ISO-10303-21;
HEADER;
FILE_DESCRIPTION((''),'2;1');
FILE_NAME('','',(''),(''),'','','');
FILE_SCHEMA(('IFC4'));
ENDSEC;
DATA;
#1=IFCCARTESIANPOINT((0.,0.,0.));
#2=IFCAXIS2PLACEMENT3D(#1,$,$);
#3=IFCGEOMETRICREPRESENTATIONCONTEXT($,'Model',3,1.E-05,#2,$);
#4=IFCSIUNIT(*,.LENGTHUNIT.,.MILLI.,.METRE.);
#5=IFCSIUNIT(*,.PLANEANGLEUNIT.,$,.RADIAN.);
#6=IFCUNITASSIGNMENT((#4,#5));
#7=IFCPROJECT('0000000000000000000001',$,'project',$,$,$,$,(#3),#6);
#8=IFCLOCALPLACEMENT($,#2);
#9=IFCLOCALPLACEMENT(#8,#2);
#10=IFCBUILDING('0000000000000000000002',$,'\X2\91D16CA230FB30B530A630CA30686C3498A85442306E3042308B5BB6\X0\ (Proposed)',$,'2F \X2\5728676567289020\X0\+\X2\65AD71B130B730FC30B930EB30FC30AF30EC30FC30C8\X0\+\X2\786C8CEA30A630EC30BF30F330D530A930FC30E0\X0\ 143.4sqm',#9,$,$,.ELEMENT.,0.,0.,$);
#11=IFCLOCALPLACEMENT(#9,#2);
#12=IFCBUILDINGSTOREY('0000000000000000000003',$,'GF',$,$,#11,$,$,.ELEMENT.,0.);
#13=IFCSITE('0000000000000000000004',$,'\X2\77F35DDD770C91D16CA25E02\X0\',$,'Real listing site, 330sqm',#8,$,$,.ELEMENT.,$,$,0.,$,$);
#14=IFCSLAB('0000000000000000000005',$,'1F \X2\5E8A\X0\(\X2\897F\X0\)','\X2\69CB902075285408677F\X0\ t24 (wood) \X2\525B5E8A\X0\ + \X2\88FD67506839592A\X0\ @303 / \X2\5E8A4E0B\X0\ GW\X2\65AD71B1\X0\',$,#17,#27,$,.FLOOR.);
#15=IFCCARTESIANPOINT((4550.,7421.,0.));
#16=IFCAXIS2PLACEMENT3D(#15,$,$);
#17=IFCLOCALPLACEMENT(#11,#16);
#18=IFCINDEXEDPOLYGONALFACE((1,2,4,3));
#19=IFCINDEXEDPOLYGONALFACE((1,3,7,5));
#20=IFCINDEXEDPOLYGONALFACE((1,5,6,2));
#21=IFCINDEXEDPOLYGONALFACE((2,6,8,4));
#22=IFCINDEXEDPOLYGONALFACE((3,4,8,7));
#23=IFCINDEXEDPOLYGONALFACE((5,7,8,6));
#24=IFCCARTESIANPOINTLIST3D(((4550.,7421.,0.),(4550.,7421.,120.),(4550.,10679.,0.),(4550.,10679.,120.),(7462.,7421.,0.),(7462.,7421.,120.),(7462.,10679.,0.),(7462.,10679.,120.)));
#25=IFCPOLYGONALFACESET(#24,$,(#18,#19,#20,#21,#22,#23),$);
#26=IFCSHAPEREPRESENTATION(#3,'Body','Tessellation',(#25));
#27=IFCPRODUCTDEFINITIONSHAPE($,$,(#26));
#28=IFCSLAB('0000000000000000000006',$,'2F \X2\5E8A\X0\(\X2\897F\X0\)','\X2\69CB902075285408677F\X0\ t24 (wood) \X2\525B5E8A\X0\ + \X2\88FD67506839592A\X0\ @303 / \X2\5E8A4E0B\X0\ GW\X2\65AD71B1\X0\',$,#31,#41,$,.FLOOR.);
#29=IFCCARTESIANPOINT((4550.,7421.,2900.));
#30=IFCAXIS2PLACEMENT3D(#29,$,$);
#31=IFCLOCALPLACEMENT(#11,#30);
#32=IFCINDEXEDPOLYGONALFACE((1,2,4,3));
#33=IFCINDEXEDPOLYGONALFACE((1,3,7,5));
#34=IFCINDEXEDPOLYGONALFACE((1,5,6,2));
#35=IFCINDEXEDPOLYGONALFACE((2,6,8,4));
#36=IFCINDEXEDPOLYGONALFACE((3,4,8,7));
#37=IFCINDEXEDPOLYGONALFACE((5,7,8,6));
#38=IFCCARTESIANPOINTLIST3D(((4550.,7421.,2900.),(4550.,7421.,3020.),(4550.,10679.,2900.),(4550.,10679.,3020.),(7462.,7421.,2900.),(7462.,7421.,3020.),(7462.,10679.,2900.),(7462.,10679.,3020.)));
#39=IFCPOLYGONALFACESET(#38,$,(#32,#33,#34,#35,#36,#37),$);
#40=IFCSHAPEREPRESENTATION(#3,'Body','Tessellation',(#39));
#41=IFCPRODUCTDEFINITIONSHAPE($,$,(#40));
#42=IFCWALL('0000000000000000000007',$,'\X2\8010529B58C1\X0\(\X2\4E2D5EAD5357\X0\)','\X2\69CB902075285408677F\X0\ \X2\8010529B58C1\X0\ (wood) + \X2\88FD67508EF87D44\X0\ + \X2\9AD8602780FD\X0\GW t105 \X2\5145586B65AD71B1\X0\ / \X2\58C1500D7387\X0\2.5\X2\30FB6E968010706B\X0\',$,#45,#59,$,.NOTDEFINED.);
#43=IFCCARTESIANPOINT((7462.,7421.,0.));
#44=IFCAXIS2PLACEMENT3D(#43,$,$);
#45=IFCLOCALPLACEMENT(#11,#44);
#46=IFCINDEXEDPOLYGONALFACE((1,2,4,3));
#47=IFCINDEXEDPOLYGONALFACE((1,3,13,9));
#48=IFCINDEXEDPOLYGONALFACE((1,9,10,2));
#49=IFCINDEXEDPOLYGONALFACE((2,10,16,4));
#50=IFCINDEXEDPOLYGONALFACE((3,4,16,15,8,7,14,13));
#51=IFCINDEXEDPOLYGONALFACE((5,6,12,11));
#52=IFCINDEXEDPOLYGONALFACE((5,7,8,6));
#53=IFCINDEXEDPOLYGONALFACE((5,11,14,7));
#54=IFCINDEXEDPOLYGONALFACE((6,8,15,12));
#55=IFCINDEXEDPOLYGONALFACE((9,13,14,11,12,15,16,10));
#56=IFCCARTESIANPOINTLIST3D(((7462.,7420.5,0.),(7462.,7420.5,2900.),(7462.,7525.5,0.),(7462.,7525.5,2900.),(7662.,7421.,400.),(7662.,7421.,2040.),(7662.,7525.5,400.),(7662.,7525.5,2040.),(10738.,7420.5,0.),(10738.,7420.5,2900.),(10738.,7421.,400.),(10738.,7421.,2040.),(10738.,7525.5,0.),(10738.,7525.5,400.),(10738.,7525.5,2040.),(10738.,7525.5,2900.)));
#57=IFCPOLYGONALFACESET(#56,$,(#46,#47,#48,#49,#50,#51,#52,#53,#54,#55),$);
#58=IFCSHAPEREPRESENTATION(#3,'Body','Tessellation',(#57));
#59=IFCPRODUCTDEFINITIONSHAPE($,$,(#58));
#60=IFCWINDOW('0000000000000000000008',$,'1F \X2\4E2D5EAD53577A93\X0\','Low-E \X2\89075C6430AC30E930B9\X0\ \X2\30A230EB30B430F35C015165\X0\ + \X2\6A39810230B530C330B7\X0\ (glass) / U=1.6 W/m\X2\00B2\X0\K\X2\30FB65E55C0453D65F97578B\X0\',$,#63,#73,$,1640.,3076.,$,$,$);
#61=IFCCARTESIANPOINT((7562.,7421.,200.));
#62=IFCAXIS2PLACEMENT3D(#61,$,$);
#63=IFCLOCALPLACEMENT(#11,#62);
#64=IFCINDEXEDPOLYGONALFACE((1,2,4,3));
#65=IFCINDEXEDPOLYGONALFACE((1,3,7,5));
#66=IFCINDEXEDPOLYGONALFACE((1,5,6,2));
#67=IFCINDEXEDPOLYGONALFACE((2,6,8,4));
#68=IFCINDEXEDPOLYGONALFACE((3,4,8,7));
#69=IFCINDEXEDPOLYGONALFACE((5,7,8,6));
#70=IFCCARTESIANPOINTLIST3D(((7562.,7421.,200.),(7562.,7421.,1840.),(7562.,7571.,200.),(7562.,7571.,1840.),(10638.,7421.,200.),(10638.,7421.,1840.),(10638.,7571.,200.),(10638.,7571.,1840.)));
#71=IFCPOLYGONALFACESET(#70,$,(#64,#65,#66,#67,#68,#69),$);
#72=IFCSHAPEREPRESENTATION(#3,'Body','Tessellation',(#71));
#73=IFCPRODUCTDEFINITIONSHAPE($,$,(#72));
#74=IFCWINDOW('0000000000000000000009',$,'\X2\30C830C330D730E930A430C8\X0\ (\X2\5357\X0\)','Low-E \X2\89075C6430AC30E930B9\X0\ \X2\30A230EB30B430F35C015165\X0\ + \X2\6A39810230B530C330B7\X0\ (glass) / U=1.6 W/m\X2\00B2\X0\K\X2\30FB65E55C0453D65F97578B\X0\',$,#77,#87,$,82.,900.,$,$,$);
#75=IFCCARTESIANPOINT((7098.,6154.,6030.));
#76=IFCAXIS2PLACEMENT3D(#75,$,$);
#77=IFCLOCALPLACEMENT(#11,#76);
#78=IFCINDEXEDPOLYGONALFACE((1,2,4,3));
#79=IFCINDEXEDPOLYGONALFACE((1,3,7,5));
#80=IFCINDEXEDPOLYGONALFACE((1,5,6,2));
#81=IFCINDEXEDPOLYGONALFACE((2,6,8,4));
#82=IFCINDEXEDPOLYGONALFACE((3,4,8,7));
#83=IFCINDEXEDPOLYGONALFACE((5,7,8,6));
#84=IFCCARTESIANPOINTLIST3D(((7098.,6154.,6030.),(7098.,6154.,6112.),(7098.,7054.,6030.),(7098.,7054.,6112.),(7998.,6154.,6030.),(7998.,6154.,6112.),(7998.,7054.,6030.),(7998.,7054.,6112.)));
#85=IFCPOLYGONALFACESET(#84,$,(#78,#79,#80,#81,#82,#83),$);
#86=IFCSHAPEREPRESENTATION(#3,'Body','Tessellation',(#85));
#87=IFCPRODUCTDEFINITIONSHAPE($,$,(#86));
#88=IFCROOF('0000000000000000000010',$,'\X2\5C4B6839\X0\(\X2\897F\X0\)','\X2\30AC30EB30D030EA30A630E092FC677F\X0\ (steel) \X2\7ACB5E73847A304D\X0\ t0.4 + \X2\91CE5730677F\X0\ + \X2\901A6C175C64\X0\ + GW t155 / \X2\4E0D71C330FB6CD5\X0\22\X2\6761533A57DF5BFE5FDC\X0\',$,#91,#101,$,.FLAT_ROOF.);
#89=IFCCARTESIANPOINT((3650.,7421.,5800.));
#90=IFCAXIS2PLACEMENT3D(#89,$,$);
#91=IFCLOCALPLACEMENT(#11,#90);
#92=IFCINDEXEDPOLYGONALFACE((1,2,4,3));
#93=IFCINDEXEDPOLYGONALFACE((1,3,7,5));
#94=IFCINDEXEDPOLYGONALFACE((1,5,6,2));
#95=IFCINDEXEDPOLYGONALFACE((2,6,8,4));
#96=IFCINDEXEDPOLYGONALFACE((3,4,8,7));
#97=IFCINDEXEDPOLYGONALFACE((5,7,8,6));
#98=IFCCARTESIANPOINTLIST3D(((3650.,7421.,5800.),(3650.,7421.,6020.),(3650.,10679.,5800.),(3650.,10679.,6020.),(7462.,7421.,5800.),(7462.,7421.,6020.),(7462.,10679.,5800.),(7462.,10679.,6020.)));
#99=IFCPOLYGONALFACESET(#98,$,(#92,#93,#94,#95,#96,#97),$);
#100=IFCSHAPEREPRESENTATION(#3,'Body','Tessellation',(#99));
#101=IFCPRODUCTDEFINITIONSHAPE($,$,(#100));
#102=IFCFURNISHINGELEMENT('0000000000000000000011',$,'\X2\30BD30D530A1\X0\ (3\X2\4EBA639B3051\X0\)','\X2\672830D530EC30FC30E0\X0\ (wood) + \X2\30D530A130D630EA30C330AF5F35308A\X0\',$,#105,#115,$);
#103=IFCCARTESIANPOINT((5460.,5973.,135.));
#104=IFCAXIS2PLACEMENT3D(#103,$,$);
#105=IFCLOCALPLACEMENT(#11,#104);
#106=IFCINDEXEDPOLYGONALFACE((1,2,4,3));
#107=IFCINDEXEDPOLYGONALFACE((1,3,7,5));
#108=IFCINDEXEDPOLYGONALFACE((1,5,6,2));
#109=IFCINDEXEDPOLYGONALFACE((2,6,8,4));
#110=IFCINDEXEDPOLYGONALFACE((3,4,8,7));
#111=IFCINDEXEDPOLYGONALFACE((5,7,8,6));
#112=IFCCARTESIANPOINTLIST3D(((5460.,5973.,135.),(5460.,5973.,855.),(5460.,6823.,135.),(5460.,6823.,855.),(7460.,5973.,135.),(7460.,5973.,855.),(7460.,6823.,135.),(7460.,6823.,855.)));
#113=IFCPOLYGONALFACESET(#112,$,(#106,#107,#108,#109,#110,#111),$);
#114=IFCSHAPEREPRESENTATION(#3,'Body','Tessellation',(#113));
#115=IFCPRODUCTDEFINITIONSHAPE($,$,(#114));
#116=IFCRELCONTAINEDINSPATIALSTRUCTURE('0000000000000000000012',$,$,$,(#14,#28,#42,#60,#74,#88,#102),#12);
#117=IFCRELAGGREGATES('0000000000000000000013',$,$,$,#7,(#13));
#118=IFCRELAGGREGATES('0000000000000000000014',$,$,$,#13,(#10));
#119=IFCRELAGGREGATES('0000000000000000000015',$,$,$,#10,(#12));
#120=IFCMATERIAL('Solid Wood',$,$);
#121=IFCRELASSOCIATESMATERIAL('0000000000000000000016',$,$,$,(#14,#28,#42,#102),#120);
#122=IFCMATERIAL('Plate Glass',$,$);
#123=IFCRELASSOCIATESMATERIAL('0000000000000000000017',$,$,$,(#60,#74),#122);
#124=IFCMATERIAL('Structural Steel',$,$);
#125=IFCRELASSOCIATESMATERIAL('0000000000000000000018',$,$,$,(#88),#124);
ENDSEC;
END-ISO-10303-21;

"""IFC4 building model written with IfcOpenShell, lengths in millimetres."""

from ifc_helpers import new_model, si_unit, frame, frame_2d, origin, place, context, project, spatial, rectangle, extrude, material, element, fill, save


model = new_model("IFC4")

# Units and contexts
model_context = context("Model", 3, precision=1e-05, world=origin())
ifc_project = project(units=[si_unit("LENGTHUNIT", "METRE", prefix="MILLI"), si_unit("PLANEANGLEUNIT", "RADIAN")], contexts=[model_context])

# Site, building, storey
site_placement = place(None, origin())
site = spatial("IfcSite", under=ifc_project, at=site_placement, Name="石川県金沢市", ObjectType="Real listing site, 330sqm", CompositionType="ELEMENT", RefElevation=0.0)
building_placement = place(site_placement, origin())
building = spatial("IfcBuilding", under=site, at=building_placement, Name="金沢・サウナと水風呂のある家 (Proposed)", ObjectType="2F 在来木造+断熱シースルークレート+硬質ウレタンフォーム 143.4sqm", CompositionType="ELEMENT", ElevationOfRefHeight=0.0, ElevationOfTerrain=0.0)
storey_placement = place(building_placement, origin())
storey = spatial("IfcBuildingStorey", under=building, at=storey_placement, Name="GF", CompositionType="ELEMENT", Elevation=0.0)

# Shared definitions
ifc_material_1 = material(Name="Solid Wood")

# Slabs
slab_1_placement = place(storey_placement, frame((4550.0, 7421.0, 0.0)))
element("IfcSlab", 1, at=slab_1_placement, inside=storey, material=ifc_material_1, Name="1F 床(西)", Description="構造用合板 t24 (wood) 剛床 + 製材根太 @303 / 床下 GW断熱", PredefinedType="FLOOR", context=model_context, shape_type="SweptSolid", body=[
    extrude(rectangle(XDim=2912.0, YDim=3258.0, at=frame_2d((1456.0, 1629.0))), frame((4550.0, 7421.0, 0.0)), (0.0, 0.0, 1.0), 120.0),
])
slab_2_placement = place(storey_placement, frame((4550.0, 7421.0, 2900.0)))
element("IfcSlab", 2, at=slab_2_placement, inside=storey, material=ifc_material_1, Name="2F 床(西)", Description="構造用合板 t24 (wood) 剛床 + 製材根太 @303 / 床下 GW断熱", PredefinedType="FLOOR", context=model_context, shape_type="SweptSolid", body=[
    extrude(rectangle(XDim=2912.0, YDim=3258.0, at=frame_2d((1456.0, 1629.0))), frame((4550.0, 7421.0, 2900.0)), (0.0, 0.0, 1.0), 120.0),
])

# Wall, opening, window
wall_placement = place(storey_placement, frame((7462.0, 7421.0, 0.0)))
wall = element("IfcWall", 3, at=wall_placement, inside=storey, material=ifc_material_1, Name="耐力壁(中庭南)", Description="構造用合板 耐力壁 (wood) + 製材軸組 + 高性能GW t105 充填断熱 / 壁倍率2.5・準耐火", PredefinedType="NOTDEFINED", context=model_context, shape_type="SweptSolid", body=[
    extrude(rectangle(XDim=3276.0, YDim=105.0, at=frame_2d((1638.0, 52.0))), frame((7462.0, 7421.0, 0.0)), (0.0, 0.0, 1.0), 2900.0),
])
opening_placement = place(storey_placement, frame((7562.0, 7421.0, 200.0)))
opening = element("IfcOpeningElement", 4, at=opening_placement, cuts=wall, PredefinedType="NOTDEFINED", context=model_context, shape_type="SweptSolid", body=[
    extrude(rectangle(XDim=3076.0, YDim=150.0, at=frame_2d((1538.0, 75.0))), frame((7562.0, 7421.0, 200.0)), (0.0, 0.0, 1.0), 1640.0),
])
ifc_material_2 = material(Name="Plate Glass")
window_1_placement = place(storey_placement, frame((7562.0, 7421.0, 200.0)))
window_1 = element("IfcWindow", 5, at=window_1_placement, inside=storey, material=ifc_material_2, Name="1F 中庭南窓", Description="Low-E 複層ガラス アルゴン封入 + 樹脂サッシ (glass) / U=1.6 W/m²K・日射取得型", OverallHeight=1640.0, OverallWidth=3076.0, context=model_context, shape_type="SweptSolid", body=[
    extrude(rectangle(XDim=3076.0, YDim=150.0, at=frame_2d((1538.0, 75.0))), frame((7562.0, 7421.0, 200.0)), (0.0, 0.0, 1.0), 1640.0),
])
fill(opening, window_1)

# Window
window_2_placement = place(storey_placement, frame((7098.0, 6154.0, 6030.0)))
element("IfcWindow", 6, at=window_2_placement, inside=storey, material=ifc_material_2, Name="トップライト (南)", Description="Low-E 複層ガラス アルゴン封入 + 樹脂サッシ (glass) / U=1.6 W/m²K・日射取得型", OverallHeight=82.0, OverallWidth=900.0, context=model_context, shape_type="SweptSolid", body=[
    extrude(rectangle(XDim=900.0, YDim=900.0, at=frame_2d((450.0, 450.0))), frame((7098.0, 6154.0, 6030.0)), (0.0, 0.0, 1.0), 82.0),
])

# Roof
ifc_material_3 = material(Name="Structural Steel")
for number, where, name in (
    (7, (3650.0, 7421.0, 5800.0), "屋根(西)"),
):
    element("IfcRoof", number, at=place(storey_placement, frame(where)), inside=storey, material=ifc_material_3, Name=name, Description="ガルバリウム鋼板 (steel) 立平葺き t0.4 + 野地板 + 通気層 + GW t155 / 不燃・法22条区域対応", PredefinedType="FLAT_ROOF", context=model_context, shape_type="SweptSolid", body=[
        extrude(rectangle(XDim=3812.0, YDim=3258.0, at=frame_2d((1906.0, 1629.0))), frame((3650.0, 7421.0, 5800.0)), (0.0, 0.0, 1.0), 220.0),
    ])

# Furnishing element
furnishing_placement = place(storey_placement, frame((5460.0, 5973.0, 135.0)))
element("IfcFurnishingElement", 8, at=furnishing_placement, inside=storey, material=ifc_material_1, Name="ソファ (3人掛け)", Description="木フレーム (wood) + ファブリック張り", context=model_context, shape_type="SweptSolid", body=[
    extrude(rectangle(XDim=2000.0, YDim=850.0, at=frame_2d((1000.0, 425.0))), frame((5460.0, 5973.0, 135.0)), (0.0, 0.0, 1.0), 720.0),
])

save(model, "model.ifc")
